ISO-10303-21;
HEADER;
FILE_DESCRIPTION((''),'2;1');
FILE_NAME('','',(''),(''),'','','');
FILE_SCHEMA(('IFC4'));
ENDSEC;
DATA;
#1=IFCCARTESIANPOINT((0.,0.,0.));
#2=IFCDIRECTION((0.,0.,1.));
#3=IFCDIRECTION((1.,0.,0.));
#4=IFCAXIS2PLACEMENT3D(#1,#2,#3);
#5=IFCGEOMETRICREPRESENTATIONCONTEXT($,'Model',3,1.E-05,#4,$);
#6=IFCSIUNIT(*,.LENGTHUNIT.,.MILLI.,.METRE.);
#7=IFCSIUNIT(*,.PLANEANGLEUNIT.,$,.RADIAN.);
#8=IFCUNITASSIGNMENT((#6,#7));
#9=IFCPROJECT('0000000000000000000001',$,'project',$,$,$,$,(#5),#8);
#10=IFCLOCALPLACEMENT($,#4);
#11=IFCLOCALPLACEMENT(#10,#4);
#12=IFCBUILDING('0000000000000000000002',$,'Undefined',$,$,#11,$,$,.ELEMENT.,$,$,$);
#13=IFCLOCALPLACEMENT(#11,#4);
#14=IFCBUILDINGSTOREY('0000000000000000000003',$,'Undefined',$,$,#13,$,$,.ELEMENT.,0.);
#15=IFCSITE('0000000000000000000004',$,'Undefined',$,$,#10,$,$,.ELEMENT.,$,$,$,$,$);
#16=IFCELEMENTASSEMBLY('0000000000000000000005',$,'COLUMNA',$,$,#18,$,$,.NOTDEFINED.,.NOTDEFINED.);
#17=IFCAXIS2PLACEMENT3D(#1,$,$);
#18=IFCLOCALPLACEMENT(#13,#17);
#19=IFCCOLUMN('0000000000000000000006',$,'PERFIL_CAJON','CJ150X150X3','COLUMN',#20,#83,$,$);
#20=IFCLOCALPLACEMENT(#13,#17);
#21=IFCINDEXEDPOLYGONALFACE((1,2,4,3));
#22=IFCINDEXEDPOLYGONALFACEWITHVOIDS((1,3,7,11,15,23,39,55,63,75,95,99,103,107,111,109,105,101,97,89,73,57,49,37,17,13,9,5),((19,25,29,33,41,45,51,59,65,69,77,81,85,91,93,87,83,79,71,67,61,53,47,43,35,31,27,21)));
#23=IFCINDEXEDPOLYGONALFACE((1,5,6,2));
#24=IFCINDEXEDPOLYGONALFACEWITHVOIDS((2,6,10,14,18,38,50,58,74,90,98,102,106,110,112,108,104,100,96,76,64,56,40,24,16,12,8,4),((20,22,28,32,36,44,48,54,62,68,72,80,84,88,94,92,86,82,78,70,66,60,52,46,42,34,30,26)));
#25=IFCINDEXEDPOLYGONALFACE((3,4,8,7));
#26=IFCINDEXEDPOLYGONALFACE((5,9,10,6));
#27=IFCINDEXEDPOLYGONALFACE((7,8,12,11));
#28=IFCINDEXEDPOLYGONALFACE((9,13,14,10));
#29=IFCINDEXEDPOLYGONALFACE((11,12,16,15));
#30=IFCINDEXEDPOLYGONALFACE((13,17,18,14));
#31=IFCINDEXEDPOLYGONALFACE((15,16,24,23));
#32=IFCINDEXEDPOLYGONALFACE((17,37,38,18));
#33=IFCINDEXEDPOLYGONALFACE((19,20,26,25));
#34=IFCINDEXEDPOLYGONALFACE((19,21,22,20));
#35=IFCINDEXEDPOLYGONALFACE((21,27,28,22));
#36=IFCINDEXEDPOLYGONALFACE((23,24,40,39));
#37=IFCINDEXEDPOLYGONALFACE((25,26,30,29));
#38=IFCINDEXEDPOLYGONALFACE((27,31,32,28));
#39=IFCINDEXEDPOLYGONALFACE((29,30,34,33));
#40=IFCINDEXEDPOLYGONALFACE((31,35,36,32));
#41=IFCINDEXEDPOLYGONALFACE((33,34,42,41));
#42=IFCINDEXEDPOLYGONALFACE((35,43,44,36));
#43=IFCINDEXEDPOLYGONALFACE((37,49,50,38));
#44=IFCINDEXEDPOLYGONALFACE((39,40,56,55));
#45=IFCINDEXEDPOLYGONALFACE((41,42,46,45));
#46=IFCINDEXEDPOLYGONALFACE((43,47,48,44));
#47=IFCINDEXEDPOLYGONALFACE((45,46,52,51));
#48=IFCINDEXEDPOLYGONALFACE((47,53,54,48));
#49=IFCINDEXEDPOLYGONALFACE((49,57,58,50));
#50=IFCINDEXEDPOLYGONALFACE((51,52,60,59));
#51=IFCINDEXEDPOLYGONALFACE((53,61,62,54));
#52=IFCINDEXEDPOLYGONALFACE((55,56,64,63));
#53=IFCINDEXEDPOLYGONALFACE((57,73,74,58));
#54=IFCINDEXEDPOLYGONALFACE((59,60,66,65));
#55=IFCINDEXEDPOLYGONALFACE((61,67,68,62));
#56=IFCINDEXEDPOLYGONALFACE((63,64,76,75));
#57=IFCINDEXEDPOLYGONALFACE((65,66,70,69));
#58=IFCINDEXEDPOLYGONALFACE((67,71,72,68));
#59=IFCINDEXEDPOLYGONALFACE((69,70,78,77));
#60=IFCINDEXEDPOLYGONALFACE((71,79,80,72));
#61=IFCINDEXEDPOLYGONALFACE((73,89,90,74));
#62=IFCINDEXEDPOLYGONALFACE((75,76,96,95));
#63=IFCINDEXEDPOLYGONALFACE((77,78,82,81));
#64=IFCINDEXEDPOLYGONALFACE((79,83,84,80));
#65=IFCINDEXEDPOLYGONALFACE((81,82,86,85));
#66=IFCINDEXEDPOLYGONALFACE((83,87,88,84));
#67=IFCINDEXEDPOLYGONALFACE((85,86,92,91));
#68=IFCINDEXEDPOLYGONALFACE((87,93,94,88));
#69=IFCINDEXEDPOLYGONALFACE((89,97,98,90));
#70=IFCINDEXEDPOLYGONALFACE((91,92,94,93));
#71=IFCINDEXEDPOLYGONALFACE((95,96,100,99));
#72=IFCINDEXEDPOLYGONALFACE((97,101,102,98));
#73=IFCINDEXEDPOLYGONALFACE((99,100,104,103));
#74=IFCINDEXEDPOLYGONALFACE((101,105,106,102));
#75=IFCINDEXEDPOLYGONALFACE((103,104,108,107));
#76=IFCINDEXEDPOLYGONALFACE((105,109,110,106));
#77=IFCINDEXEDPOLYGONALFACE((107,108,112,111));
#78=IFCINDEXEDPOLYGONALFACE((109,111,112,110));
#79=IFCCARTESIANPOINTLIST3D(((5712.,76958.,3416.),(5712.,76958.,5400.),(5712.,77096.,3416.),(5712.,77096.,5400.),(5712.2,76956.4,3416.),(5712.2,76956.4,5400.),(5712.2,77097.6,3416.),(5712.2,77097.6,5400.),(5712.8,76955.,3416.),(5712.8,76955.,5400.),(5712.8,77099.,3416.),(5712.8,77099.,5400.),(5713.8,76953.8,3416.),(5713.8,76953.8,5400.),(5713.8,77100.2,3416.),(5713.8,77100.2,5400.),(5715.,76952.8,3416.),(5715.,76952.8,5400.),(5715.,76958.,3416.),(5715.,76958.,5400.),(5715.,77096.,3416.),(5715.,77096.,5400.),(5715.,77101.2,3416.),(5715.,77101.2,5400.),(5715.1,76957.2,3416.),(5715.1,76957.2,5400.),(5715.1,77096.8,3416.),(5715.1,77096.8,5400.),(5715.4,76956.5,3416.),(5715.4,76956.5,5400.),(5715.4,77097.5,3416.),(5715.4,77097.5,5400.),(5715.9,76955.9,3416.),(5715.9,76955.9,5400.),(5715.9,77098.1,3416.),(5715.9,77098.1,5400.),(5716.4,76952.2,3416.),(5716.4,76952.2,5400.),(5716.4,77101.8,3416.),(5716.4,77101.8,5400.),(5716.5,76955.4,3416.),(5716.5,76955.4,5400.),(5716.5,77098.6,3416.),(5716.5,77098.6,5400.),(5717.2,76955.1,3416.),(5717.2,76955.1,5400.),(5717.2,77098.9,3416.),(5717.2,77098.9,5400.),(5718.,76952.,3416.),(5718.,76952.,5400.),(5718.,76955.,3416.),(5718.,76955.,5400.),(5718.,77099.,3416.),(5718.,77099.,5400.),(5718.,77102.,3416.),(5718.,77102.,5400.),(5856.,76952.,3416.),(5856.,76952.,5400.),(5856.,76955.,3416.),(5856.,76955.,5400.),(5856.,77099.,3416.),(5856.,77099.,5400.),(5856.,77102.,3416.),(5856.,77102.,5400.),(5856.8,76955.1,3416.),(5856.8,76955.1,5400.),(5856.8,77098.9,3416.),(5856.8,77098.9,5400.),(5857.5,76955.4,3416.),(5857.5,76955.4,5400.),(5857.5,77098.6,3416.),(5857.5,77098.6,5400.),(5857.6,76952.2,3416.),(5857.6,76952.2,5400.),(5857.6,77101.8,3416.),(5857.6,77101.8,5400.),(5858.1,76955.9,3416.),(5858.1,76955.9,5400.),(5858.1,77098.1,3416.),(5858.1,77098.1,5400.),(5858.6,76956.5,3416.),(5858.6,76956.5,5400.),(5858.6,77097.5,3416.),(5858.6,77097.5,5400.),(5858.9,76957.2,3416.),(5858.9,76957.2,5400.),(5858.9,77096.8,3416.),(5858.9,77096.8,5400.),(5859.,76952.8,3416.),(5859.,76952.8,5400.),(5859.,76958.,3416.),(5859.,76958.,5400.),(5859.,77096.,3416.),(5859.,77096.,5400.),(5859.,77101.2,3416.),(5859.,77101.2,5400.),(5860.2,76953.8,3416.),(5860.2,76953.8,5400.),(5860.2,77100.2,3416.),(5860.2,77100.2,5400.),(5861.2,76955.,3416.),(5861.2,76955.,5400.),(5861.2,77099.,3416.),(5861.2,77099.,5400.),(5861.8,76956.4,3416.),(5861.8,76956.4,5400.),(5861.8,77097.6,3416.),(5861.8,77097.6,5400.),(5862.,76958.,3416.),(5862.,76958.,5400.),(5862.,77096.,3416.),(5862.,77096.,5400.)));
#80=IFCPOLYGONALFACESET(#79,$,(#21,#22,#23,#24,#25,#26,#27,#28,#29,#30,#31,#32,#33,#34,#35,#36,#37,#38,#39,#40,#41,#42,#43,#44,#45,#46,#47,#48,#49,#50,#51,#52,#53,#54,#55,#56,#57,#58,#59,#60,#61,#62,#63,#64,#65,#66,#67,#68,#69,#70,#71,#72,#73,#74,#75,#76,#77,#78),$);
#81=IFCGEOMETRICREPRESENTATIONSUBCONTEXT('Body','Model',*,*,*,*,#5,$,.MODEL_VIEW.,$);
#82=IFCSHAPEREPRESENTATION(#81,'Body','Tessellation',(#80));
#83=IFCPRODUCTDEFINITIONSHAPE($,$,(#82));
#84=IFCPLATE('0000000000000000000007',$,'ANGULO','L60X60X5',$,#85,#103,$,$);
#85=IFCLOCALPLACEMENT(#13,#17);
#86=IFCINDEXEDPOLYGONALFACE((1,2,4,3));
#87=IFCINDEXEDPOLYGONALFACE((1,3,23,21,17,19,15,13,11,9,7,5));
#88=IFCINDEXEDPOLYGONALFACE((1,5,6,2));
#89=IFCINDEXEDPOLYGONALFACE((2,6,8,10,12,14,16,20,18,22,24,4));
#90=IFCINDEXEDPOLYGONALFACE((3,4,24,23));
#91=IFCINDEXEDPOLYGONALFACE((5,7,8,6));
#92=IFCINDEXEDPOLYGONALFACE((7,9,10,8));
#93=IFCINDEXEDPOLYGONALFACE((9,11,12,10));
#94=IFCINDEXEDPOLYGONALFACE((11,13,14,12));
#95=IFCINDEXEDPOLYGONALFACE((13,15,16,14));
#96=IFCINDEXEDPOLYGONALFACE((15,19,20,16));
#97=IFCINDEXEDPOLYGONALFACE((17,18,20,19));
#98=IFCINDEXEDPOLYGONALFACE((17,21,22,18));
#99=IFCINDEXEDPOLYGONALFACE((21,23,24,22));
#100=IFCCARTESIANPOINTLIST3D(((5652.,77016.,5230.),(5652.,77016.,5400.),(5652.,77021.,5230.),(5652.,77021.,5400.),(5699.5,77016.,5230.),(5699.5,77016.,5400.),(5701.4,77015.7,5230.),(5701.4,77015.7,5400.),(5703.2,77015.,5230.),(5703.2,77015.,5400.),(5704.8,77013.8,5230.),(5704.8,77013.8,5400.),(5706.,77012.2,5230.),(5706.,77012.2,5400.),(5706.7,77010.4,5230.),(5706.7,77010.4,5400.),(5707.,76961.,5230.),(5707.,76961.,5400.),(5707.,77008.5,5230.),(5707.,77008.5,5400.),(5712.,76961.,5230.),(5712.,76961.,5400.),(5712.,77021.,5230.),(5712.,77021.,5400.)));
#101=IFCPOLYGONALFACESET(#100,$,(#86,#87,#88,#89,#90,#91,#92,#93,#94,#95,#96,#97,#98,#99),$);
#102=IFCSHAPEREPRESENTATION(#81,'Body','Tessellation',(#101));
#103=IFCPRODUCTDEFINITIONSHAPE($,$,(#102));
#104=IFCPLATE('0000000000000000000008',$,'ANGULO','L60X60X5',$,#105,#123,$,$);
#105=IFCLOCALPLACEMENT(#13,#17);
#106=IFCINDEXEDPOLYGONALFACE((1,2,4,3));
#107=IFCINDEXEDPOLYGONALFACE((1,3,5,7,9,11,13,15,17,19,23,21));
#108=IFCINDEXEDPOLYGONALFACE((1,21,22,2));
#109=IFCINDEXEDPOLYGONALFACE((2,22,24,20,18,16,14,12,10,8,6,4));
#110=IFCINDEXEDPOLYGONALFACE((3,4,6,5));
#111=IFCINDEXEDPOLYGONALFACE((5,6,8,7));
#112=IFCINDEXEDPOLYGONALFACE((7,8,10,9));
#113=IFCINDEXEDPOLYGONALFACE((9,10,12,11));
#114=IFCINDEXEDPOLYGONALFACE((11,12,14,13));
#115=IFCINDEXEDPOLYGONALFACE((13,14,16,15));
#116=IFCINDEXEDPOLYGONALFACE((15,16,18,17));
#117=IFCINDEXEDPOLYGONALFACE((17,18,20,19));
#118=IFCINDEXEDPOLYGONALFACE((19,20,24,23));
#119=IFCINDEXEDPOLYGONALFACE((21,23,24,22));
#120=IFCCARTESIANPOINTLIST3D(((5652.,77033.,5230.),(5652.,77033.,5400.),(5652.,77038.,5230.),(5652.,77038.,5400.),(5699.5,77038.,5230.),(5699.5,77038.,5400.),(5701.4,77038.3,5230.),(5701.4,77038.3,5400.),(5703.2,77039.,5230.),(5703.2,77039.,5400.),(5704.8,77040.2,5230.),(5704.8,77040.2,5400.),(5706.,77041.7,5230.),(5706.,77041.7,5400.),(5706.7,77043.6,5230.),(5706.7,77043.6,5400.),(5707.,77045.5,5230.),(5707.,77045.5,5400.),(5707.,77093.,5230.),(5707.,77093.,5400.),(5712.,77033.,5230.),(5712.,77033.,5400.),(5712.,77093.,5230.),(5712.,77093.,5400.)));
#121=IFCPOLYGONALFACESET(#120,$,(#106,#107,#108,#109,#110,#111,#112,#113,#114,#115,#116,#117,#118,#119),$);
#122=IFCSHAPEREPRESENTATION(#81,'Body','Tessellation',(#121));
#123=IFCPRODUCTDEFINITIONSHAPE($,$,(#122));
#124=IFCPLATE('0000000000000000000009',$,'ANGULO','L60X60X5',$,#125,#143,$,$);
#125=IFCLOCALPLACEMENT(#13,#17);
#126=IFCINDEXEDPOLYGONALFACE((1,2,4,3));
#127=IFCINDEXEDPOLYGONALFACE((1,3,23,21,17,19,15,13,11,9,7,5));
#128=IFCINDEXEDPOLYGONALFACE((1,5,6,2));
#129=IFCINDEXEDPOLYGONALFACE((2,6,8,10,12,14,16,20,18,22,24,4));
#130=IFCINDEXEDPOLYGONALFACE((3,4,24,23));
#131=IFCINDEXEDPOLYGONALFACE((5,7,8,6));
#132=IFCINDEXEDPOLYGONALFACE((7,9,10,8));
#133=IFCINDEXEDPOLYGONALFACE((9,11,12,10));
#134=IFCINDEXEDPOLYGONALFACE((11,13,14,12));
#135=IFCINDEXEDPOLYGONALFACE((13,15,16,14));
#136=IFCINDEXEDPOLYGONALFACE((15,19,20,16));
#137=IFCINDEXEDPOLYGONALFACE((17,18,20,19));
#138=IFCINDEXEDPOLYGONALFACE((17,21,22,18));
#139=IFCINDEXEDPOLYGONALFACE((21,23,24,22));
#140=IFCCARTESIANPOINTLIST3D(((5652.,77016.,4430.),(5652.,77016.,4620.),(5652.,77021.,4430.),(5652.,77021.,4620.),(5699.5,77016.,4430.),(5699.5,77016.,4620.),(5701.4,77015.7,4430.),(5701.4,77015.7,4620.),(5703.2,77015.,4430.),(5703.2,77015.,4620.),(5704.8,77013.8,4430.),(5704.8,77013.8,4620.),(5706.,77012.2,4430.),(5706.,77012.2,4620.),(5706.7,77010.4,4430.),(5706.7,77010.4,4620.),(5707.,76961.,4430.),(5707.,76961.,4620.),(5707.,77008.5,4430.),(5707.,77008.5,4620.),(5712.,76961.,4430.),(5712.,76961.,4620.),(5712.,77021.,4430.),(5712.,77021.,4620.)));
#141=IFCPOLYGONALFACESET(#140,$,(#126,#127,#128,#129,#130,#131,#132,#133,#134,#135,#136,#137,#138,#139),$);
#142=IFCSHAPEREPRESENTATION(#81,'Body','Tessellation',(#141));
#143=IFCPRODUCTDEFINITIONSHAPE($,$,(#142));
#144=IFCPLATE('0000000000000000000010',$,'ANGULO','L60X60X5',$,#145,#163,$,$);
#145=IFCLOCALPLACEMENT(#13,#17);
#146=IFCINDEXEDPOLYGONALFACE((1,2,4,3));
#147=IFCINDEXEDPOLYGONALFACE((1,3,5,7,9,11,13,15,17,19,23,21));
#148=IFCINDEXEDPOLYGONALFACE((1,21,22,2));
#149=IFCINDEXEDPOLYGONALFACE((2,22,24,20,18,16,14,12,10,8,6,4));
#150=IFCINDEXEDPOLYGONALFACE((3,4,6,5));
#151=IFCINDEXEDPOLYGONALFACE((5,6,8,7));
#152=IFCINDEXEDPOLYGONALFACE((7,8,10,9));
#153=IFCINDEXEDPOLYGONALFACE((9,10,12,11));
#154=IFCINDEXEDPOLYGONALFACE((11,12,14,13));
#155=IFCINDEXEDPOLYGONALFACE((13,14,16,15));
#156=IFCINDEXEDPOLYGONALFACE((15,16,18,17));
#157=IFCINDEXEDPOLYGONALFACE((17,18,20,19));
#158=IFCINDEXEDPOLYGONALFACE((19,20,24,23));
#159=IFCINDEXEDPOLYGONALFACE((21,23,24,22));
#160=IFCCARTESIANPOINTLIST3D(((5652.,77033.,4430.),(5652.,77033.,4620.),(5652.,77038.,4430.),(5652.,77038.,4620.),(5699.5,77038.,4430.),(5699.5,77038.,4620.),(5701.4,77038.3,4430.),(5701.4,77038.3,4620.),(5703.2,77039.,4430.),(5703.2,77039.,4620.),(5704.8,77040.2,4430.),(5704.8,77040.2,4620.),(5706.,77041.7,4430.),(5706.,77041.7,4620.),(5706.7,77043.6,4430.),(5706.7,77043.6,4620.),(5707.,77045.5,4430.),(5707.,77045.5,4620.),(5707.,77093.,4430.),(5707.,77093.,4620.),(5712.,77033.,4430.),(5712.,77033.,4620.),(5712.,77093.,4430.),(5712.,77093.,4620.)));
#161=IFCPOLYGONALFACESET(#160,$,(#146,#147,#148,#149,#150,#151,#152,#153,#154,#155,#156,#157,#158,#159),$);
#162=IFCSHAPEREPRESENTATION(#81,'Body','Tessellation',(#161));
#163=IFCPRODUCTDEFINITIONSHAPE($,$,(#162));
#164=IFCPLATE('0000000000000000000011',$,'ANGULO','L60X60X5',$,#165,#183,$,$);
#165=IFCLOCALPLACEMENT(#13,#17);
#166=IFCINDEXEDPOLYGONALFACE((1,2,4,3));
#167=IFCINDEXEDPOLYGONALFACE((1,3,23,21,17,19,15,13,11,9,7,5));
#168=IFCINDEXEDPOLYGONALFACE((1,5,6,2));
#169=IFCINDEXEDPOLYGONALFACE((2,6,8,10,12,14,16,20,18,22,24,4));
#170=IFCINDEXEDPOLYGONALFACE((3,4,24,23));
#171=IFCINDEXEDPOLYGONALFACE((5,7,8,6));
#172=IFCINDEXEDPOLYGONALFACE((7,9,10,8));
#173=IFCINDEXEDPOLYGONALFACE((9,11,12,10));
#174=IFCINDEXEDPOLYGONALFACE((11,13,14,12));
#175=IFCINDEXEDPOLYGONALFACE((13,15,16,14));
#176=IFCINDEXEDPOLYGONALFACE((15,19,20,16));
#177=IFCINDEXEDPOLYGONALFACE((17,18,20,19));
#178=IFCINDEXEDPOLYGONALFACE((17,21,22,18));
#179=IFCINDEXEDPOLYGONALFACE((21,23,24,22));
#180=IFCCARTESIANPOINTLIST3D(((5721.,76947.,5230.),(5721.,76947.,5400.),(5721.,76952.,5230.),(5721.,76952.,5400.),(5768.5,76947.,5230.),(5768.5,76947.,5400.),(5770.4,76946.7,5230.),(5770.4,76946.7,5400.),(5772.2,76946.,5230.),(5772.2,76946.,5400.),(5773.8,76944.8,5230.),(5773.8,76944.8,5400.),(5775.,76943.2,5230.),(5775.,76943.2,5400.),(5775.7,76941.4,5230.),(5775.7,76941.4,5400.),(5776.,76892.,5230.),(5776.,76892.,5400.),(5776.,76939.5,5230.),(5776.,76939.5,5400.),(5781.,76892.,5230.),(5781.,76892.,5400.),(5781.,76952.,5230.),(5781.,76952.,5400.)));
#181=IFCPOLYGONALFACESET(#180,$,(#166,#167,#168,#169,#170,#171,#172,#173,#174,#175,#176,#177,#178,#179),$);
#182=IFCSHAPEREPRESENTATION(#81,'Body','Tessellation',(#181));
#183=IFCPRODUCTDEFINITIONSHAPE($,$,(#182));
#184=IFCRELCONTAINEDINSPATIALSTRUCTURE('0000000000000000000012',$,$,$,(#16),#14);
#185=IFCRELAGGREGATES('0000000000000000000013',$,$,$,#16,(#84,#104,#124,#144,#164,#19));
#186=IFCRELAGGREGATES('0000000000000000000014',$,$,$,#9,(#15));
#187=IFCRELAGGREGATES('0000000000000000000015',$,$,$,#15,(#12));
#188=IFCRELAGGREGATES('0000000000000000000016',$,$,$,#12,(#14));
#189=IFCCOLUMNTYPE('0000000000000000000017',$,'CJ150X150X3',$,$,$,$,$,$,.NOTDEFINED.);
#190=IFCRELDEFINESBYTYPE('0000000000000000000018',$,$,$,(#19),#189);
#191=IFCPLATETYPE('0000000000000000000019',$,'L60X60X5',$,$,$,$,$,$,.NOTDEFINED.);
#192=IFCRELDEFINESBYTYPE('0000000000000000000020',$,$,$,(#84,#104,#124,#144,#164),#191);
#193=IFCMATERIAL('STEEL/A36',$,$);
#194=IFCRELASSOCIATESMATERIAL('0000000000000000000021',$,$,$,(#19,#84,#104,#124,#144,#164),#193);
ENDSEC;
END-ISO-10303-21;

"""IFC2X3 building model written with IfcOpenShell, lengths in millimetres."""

from ifc_helpers import new_model, si_unit, frame, origin_with_axes, origin_2d_with_axis, place, context, subcontext, project, spatial, hollow_rectangle, l_section, extrude, material, type_object, element, aggregate, save


model = new_model("IFC2X3")

# Units and contexts
model_context = context("Model", 3, precision=1e-05, world=origin_with_axes())
body_context = subcontext(model_context, "Body", "Model", "MODEL_VIEW")
ifc_project = project(units=[si_unit("LENGTHUNIT", "METRE", prefix="MILLI"), si_unit("PLANEANGLEUNIT", "RADIAN")], contexts=[model_context])

# Site, building, storey
site_placement = place(None, origin_with_axes())
site = spatial("IfcSite", under=ifc_project, at=site_placement, Name="Undefined", CompositionType="ELEMENT")
building_placement = place(site_placement, origin_with_axes())
building = spatial("IfcBuilding", under=site, at=building_placement, Name="Undefined", CompositionType="ELEMENT")
storey_placement = place(building_placement, origin_with_axes())
storey = spatial("IfcBuildingStorey", under=building, at=storey_placement, Name="Undefined", CompositionType="ELEMENT", Elevation=0.0)

# Element assembly, column, plates
assembly_1_placement = place(storey_placement, origin_with_axes())
assembly_1 = element("IfcElementAssembly", 1, at=assembly_1_placement, inside=storey, Name="COLUMNA", AssemblyPlace="NOTDEFINED", PredefinedType="NOTDEFINED")
ifc_material_1 = material(Name="STEEL/A36")
column_type = type_object("IfcColumnType", Name="CJ150X150X3", PredefinedType="NOTDEFINED")
column_placement = place(assembly_1_placement, frame((5787.0, 77027.0, 3416.0), z_axis=(0.0, 0.0, 1.0), x_axis=(-1.0, 0.0, 0.0)))
column = element("IfcColumn", 2, at=column_placement, type_object=column_type, material=ifc_material_1, Name="PERFIL_CAJON", Description="CJ150X150X3", ObjectType="COLUMN", context=body_context, shape_type="SweptSolid", body=[
    extrude(hollow_rectangle(XDim=150.0, YDim=150.0, WallThickness=3.0, InnerFilletRadius=3.0, OuterFilletRadius=6.0, at=origin_2d_with_axis()), frame((0.0, 0.0, 1984.0), z_axis=(0.0, 0.0, -1.0), x_axis=(0.0, 1.0, 0.0)), (0.0, 0.0, 1.0), 1984.0),
])
plate_type_1 = type_object("IfcPlateType", Name="L60X60X5", PredefinedType="NOTDEFINED")
plate_1_placement = place(assembly_1_placement, frame((5682.0, 76991.0, 5400.0), z_axis=(0.0, -1.0, 0.0), x_axis=(0.0, 0.0, -1.0)))
plate_1 = element("IfcPlate", 3, at=plate_1_placement, type_object=plate_type_1, material=ifc_material_1, Name="ANGULO", Description="L60X60X5", context=body_context, shape_type="SweptSolid", body=[
    extrude(l_section(Depth=60.0, Width=60.0, Thickness=5.0, FilletRadius=7.5, at=origin_2d_with_axis()), frame((170.0, 0.0, 0.0), z_axis=(-1.0, 0.0, 0.0), x_axis=(0.0, -1.0, 0.0)), (0.0, 0.0, 1.0), 170.0),
])
plate_2_placement = place(assembly_1_placement, frame((5682.0, 77063.0, 5230.0), z_axis=(0.0, 1.0, 0.0), x_axis=(0.0, 0.0, 1.0)))
plate_2 = element("IfcPlate", 4, at=plate_2_placement, type_object=plate_type_1, material=ifc_material_1, Name="ANGULO", Description="L60X60X5", context=body_context, shape_type="SweptSolid", body=[
    extrude(l_section(Depth=60.0, Width=60.0, Thickness=5.0, FilletRadius=7.5, at=origin_2d_with_axis()), frame((170.0, 0.0, 0.0), z_axis=(-1.0, 0.0, 0.0), x_axis=(0.0, -1.0, 0.0)), (0.0, 0.0, 1.0), 170.0),
])
plate_3_placement = place(assembly_1_placement, frame((5682.0, 76991.0, 4620.0), z_axis=(0.0, -1.0, 0.0), x_axis=(0.0, 0.0, -1.0)))
plate_3 = element("IfcPlate", 5, at=plate_3_placement, type_object=plate_type_1, material=ifc_material_1, Name="ANGULO", Description="L60X60X5", context=body_context, shape_type="SweptSolid", body=[
    extrude(l_section(Depth=60.0, Width=60.0, Thickness=5.0, FilletRadius=7.5, at=origin_2d_with_axis()), frame((190.0, 0.0, 0.0), z_axis=(-1.0, 0.0, 0.0), x_axis=(0.0, -1.0, 0.0)), (0.0, 0.0, 1.0), 190.0),
])
plate_4_placement = place(assembly_1_placement, frame((5682.0, 77063.0, 4430.0), z_axis=(0.0, 1.0, 0.0), x_axis=(0.0, 0.0, 1.0)))
plate_4 = element("IfcPlate", 6, at=plate_4_placement, type_object=plate_type_1, material=ifc_material_1, Name="ANGULO", Description="L60X60X5", context=body_context, shape_type="SweptSolid", body=[
    extrude(l_section(Depth=60.0, Width=60.0, Thickness=5.0, FilletRadius=7.5, at=origin_2d_with_axis()), frame((190.0, 0.0, 0.0), z_axis=(-1.0, 0.0, 0.0), x_axis=(0.0, -1.0, 0.0)), (0.0, 0.0, 1.0), 190.0),
])
plate_5_placement = place(assembly_1_placement, frame((5751.0, 76922.0, 5230.0), z_axis=(-1.0, 0.0, 0.0), x_axis=(0.0, 0.0, 1.0)))
plate_5 = element("IfcPlate", 7, at=plate_5_placement, type_object=plate_type_1, material=ifc_material_1, Name="ANGULO", Description="L60X60X5", context=body_context, shape_type="SweptSolid", body=[
    extrude(l_section(Depth=60.0, Width=60.0, Thickness=5.0, FilletRadius=7.5, at=origin_2d_with_axis()), frame((170.0, 0.0, 0.0), z_axis=(-1.0, 0.0, 0.0), x_axis=(0.0, -1.0, 0.0)), (0.0, 0.0, 1.0), 170.0),
])

aggregate(assembly_1, [plate_1, plate_2, plate_3, plate_4, plate_5, column])

save(model, "model.ifc")
